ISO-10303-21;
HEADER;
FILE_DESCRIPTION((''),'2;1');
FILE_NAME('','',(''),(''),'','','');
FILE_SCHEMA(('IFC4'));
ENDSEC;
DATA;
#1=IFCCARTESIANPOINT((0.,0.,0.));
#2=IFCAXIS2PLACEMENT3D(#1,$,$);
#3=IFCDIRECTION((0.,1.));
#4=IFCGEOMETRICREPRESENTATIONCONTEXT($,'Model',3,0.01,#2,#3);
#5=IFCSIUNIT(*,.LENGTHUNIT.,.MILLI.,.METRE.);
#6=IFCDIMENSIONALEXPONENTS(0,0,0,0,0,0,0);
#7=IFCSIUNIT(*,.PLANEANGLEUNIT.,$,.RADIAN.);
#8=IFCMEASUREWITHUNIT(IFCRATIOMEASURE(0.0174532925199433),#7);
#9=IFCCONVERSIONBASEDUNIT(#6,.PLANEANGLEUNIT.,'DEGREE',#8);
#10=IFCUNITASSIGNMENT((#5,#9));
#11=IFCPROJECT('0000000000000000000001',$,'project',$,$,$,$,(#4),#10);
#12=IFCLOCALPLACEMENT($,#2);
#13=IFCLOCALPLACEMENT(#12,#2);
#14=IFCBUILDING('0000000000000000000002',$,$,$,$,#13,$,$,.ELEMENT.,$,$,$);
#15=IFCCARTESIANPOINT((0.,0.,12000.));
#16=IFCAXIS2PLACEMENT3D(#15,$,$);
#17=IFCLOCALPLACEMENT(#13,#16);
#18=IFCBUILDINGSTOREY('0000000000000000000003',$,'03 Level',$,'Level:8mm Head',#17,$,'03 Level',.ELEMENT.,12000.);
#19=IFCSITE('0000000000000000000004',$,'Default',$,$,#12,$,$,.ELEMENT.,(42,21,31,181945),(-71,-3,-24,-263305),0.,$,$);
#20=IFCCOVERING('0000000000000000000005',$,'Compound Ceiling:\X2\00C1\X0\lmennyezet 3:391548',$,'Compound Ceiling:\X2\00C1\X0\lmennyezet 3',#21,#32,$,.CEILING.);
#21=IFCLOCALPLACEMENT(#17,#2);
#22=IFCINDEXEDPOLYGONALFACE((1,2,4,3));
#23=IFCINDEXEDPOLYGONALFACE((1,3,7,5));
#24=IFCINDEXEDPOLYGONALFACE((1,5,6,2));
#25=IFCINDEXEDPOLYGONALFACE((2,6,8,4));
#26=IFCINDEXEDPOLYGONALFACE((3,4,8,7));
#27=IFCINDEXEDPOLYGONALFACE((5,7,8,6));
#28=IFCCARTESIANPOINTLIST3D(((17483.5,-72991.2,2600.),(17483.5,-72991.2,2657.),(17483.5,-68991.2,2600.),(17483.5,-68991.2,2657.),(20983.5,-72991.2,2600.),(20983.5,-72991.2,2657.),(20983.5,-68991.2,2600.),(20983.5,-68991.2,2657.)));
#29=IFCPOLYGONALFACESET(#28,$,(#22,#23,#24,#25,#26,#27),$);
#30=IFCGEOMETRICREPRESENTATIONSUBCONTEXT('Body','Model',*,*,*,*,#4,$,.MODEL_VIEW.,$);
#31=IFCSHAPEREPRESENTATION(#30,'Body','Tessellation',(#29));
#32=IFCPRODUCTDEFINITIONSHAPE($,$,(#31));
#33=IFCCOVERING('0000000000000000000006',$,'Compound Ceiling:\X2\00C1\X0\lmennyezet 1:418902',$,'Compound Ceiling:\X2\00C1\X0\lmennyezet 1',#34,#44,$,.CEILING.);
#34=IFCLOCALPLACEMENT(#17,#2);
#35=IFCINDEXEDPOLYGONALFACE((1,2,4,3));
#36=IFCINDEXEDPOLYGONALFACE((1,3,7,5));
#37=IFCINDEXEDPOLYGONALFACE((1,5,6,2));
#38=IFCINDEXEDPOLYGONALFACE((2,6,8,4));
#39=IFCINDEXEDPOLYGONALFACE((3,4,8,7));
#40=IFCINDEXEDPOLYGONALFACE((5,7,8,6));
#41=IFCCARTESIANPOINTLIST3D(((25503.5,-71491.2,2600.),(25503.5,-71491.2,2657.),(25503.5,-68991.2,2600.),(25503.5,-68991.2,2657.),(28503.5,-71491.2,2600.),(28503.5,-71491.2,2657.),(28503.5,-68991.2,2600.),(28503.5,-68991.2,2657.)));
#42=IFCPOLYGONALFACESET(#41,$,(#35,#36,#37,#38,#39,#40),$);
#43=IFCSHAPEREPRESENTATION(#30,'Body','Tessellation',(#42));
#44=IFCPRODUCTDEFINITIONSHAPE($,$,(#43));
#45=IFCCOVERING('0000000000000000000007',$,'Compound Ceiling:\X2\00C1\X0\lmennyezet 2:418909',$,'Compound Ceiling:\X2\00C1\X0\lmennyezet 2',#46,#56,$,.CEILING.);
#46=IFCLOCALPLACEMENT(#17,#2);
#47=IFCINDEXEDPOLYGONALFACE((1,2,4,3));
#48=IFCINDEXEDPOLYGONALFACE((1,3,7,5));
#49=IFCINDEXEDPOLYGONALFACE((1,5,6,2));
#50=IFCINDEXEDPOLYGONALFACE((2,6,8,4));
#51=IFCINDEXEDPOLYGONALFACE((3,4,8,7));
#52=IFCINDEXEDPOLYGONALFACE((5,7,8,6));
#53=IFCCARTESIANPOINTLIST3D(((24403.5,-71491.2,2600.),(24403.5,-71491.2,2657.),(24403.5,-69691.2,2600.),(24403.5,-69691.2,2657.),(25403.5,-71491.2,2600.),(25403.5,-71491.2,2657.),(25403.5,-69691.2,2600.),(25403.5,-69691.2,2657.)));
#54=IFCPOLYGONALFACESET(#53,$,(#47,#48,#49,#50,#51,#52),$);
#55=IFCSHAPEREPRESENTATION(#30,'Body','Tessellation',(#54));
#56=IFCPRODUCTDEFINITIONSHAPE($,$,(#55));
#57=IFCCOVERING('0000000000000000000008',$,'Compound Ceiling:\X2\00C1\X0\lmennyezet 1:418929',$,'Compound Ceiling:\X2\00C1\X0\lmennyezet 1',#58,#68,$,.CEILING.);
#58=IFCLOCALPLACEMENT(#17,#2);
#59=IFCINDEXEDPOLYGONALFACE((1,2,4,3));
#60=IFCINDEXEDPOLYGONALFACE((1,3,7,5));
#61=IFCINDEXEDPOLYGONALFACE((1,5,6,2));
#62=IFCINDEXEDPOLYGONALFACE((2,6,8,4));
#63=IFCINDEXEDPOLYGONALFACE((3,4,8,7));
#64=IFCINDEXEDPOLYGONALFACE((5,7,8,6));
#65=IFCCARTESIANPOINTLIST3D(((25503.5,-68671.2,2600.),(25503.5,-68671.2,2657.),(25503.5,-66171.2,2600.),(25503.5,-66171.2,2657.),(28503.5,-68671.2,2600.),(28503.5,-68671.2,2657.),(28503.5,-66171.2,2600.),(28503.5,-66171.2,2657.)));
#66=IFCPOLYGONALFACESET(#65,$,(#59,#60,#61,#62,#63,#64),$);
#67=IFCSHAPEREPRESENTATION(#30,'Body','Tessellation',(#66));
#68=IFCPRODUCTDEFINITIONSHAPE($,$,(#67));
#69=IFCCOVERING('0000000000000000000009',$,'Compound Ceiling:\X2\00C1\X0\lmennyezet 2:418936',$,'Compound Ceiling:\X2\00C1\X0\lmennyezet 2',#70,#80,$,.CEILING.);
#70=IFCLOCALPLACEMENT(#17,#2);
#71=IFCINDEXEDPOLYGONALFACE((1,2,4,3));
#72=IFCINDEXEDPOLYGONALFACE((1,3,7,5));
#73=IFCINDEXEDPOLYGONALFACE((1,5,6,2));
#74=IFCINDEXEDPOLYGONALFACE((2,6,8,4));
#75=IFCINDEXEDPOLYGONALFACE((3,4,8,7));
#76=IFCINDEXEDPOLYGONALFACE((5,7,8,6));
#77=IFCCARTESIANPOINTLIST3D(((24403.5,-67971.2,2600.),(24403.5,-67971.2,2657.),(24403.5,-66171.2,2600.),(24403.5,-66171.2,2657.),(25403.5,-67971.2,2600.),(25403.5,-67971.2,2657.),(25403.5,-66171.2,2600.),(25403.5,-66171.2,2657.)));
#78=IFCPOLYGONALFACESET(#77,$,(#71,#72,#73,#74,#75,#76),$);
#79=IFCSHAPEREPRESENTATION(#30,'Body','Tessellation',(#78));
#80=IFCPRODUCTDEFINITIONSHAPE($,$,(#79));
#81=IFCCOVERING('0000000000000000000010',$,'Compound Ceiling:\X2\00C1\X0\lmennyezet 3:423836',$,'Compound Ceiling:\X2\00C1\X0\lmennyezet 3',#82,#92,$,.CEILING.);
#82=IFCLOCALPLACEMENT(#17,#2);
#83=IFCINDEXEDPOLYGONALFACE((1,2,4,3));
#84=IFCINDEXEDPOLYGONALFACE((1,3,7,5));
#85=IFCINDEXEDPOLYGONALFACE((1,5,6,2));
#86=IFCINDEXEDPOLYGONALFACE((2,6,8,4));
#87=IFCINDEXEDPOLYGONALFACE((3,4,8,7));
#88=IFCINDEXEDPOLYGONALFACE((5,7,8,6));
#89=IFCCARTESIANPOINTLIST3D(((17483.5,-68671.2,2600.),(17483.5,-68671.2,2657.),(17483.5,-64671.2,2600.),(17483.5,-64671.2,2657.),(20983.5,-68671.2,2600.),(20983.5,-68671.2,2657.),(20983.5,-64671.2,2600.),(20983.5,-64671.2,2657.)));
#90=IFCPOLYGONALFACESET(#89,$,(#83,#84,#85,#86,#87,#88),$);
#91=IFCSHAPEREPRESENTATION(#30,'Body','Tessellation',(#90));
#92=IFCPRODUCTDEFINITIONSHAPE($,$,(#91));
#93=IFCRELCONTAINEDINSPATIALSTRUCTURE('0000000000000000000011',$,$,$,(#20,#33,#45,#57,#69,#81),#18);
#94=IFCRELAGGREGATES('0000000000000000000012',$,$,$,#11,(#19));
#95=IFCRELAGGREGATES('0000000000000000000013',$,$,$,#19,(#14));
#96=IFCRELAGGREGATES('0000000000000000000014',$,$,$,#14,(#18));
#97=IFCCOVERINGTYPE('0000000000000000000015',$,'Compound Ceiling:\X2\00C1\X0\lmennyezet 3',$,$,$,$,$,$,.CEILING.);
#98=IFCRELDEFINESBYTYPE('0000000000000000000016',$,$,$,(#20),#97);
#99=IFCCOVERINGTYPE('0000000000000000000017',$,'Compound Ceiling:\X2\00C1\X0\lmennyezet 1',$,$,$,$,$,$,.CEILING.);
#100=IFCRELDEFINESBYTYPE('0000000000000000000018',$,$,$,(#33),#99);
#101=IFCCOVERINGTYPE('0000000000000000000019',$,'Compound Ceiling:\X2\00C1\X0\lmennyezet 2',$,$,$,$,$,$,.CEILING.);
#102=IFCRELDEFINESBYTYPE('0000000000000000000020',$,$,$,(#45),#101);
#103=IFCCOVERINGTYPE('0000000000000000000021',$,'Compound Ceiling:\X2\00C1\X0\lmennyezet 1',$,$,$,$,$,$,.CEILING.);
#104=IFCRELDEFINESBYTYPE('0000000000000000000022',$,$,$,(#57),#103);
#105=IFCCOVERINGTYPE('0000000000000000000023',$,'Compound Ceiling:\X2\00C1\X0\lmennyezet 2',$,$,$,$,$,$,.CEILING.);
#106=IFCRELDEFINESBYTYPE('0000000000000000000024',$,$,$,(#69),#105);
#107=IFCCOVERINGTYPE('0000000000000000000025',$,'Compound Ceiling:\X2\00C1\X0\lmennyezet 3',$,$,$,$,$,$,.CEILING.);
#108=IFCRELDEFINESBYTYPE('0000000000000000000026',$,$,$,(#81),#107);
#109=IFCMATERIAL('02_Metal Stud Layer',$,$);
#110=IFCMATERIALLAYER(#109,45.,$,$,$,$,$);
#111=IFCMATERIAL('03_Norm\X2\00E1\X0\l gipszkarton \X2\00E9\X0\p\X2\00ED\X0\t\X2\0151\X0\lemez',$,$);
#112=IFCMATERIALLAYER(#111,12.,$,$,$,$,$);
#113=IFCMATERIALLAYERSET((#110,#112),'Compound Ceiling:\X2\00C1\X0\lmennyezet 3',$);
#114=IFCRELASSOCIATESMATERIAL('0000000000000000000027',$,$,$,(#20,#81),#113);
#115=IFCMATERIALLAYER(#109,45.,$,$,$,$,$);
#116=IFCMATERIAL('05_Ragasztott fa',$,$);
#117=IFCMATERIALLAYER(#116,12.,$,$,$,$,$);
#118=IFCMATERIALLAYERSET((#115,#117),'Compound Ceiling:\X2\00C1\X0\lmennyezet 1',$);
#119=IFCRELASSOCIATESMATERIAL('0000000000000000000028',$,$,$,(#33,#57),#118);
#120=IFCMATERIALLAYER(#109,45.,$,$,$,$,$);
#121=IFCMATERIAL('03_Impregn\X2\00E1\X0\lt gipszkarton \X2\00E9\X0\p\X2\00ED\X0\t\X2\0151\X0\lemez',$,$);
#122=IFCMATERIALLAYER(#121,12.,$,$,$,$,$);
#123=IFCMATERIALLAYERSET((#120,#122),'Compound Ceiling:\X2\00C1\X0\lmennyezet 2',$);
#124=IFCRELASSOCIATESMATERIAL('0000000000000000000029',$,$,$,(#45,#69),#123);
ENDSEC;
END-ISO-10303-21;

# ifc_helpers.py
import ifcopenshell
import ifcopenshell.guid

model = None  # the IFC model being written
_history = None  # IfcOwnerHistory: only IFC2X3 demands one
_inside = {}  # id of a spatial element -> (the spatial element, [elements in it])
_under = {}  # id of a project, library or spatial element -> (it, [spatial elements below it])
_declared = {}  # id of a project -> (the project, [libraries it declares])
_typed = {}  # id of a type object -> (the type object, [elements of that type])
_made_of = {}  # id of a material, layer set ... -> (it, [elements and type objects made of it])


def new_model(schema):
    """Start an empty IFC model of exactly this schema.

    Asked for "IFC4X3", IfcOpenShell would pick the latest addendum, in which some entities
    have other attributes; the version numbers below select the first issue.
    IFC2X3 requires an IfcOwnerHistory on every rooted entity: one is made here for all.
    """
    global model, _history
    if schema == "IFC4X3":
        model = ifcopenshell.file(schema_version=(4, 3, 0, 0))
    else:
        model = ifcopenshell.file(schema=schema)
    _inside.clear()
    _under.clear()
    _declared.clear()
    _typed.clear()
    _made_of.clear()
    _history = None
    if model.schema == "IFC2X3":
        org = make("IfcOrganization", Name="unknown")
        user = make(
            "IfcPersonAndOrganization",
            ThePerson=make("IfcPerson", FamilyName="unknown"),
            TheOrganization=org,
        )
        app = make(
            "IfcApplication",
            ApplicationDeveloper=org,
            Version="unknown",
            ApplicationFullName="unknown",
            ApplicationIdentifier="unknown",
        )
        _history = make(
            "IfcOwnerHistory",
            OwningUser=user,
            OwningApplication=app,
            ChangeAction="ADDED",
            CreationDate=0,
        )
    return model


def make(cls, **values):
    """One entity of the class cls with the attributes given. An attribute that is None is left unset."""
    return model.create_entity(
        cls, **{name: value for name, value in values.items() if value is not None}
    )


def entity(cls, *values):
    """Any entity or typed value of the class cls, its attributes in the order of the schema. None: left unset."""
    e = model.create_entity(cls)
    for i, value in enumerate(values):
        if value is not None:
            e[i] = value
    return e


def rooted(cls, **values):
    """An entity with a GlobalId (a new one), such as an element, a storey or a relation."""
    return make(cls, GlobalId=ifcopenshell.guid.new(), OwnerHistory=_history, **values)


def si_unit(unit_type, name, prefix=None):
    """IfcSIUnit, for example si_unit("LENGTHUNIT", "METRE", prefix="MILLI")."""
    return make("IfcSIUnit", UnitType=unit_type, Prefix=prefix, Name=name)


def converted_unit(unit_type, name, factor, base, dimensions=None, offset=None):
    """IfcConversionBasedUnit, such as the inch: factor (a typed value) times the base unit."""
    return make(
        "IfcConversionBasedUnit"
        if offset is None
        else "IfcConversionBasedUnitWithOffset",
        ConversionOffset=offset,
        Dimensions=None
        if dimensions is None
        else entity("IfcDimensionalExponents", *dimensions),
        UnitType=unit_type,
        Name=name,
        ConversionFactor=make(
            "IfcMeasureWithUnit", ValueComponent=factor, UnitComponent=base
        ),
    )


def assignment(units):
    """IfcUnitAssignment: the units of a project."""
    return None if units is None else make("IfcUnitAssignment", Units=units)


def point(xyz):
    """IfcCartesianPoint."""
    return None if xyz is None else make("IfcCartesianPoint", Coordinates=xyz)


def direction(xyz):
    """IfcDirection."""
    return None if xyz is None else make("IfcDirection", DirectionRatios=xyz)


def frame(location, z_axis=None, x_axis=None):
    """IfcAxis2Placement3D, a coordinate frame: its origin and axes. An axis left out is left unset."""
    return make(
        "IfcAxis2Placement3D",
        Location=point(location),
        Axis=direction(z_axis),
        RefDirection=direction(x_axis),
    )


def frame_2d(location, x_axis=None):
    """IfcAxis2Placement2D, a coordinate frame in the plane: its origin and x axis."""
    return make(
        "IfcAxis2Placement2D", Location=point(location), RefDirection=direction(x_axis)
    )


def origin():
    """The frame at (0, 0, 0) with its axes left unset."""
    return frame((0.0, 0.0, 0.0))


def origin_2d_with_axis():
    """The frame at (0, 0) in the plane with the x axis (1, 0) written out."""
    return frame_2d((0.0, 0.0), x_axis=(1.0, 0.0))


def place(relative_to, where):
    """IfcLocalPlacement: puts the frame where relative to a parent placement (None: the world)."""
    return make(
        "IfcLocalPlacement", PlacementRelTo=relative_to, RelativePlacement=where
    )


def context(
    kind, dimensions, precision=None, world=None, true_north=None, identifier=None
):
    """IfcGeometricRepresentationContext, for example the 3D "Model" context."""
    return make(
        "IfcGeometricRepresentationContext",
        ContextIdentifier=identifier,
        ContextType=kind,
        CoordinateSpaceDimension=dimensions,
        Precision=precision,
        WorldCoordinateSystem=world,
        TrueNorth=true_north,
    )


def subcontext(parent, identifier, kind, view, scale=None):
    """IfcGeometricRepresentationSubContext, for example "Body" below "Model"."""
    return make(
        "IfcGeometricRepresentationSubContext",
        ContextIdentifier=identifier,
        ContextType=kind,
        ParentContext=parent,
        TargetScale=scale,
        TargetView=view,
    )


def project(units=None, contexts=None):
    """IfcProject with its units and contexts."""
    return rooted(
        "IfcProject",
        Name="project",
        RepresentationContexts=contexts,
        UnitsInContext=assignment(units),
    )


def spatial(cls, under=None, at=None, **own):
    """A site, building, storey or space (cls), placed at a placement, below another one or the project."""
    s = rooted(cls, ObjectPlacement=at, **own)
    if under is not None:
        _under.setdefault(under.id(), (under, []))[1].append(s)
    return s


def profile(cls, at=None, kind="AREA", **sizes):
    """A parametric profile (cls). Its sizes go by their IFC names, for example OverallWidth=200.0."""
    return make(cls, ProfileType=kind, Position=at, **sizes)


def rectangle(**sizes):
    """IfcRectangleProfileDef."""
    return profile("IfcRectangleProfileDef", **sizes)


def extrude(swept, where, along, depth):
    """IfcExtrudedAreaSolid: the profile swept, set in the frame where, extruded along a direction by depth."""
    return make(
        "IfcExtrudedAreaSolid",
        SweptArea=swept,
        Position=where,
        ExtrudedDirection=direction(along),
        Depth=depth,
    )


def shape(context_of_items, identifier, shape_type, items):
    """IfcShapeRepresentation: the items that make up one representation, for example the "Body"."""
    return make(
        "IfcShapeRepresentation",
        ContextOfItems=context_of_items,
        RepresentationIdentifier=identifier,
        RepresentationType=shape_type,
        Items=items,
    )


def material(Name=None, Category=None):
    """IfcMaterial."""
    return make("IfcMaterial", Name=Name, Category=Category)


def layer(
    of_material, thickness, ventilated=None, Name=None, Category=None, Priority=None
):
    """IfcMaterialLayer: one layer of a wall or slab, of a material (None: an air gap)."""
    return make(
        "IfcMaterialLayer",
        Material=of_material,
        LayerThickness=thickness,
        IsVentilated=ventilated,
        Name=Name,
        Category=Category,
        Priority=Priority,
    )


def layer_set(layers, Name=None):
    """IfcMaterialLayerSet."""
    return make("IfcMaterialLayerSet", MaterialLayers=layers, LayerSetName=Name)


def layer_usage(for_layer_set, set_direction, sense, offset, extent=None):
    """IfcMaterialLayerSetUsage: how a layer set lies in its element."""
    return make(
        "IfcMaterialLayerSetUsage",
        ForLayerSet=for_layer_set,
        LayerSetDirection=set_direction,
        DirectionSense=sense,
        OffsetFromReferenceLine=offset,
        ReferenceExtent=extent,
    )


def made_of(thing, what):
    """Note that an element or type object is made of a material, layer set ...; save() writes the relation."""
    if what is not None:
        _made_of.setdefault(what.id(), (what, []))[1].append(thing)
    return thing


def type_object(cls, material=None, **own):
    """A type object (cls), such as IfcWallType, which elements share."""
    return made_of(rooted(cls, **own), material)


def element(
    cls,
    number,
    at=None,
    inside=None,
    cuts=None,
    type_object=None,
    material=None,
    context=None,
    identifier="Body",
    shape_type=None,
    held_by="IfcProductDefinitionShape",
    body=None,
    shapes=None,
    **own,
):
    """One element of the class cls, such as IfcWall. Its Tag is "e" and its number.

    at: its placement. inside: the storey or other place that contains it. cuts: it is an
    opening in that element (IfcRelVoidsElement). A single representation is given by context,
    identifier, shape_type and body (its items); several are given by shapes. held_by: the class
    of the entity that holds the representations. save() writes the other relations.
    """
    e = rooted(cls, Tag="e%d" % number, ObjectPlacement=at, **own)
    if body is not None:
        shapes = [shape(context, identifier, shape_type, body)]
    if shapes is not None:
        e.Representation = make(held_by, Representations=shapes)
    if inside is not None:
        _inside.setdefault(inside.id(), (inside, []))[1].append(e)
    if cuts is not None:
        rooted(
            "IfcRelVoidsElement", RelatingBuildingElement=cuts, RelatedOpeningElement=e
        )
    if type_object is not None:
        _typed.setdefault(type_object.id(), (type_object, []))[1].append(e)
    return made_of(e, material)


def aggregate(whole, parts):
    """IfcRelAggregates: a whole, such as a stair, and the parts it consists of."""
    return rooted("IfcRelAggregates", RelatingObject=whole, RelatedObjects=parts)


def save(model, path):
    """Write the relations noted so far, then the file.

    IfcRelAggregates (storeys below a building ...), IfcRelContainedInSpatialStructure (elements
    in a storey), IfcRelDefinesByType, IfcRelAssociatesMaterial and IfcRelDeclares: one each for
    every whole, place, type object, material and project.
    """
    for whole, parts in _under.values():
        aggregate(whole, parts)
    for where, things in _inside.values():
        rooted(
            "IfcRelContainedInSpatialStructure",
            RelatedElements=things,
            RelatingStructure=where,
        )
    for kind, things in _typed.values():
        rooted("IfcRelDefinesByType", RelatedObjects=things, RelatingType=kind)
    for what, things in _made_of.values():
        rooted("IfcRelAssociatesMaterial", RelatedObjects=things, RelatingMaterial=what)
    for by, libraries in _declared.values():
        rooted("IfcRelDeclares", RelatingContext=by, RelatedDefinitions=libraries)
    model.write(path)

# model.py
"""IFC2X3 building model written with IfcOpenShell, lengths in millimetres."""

from ifc_helpers import new_model, entity, si_unit, converted_unit, direction, frame, frame_2d, origin, origin_2d_with_axis, place, context, subcontext, project, spatial, rectangle, extrude, material, layer, layer_set, layer_usage, type_object, element, save


model = new_model("IFC2X3")

# Units and contexts
model_context = context("Model", 3, precision=0.01, world=origin(), true_north=direction((0.0, 1.0)))
body_context = subcontext(model_context, "Body", "Model", "MODEL_VIEW")
ifc_project = project(units=[si_unit("LENGTHUNIT", "METRE", prefix="MILLI"), converted_unit("PLANEANGLEUNIT", "DEGREE", entity("IfcRatioMeasure", 0.0174532925199433), si_unit("PLANEANGLEUNIT", "RADIAN"), dimensions=[0, 0, 0, 0, 0, 0, 0])], contexts=[model_context])

# Site, building, storey
site_placement = place(None, origin())
site = spatial("IfcSite", under=ifc_project, at=site_placement, Name="Default", CompositionType="ELEMENT", RefLatitude=(42, 21, 31, 181945), RefLongitude=(-71, -3, -24, -263305), RefElevation=0.0)
building_placement = place(site_placement, origin())
building = spatial("IfcBuilding", under=site, at=building_placement, CompositionType="ELEMENT")
storey_placement = place(building_placement, frame((0.0, 0.0, 12000.0)))
storey = spatial("IfcBuildingStorey", under=building, at=storey_placement, Name="03 Level", ObjectType="Level:8mm Head", LongName="03 Level", CompositionType="ELEMENT", Elevation=12000.0)

# Coverings
ifc_material_1 = material(Name="02_Metal Stud Layer")
ifc_layer_1 = layer(ifc_material_1, 45.0)
ifc_material_2 = material(Name="03_Normál gipszkarton építőlemez")
ifc_layer_2 = layer(ifc_material_2, 12.0)
ifc_layer_set_1 = layer_set([ifc_layer_1, ifc_layer_2], Name="Compound Ceiling:Álmennyezet 3")
ifc_layer_usage_1 = layer_usage(ifc_layer_set_1, "AXIS3", "POSITIVE", 0.0)
covering_type_1 = type_object("IfcCoveringType", Name="Compound Ceiling:Álmennyezet 3", PredefinedType="CEILING")
covering_1_placement = place(storey_placement, frame((17483.5, -72991.2, 2600.0)))
element("IfcCovering", 1, at=covering_1_placement, inside=storey, type_object=covering_type_1, material=ifc_layer_usage_1, Name="Compound Ceiling:Álmennyezet 3:391548", ObjectType="Compound Ceiling:Álmennyezet 3", PredefinedType="CEILING", context=body_context, shape_type="SweptSolid", body=[
    extrude(rectangle(XDim=4000.0, YDim=3500.0, at=frame_2d((0.0, 0.0), x_axis=(1.0, 0.0))), frame((1750.0, 2000.0, 0.0), z_axis=(0.0, 0.0, 1.0), x_axis=(0.0, 1.0, 0.0)), (0.0, 0.0, 1.0), 57.0),
])
ifc_layer_3 = layer(ifc_material_1, 45.0)
ifc_material_3 = material(Name="05_Ragasztott fa")
ifc_layer_4 = layer(ifc_material_3, 12.0)
ifc_layer_set_2 = layer_set([ifc_layer_3, ifc_layer_4], Name="Compound Ceiling:Álmennyezet 1")
ifc_layer_usage_2 = layer_usage(ifc_layer_set_2, "AXIS3", "POSITIVE", 0.0)
covering_type_2 = type_object("IfcCoveringType", Name="Compound Ceiling:Álmennyezet 1", PredefinedType="CEILING")
covering_2_placement = place(storey_placement, frame((25503.5, -71491.2, 2600.0)))
element("IfcCovering", 2, at=covering_2_placement, inside=storey, type_object=covering_type_2, material=ifc_layer_usage_2, Name="Compound Ceiling:Álmennyezet 1:418902", ObjectType="Compound Ceiling:Álmennyezet 1", PredefinedType="CEILING", context=body_context, shape_type="SweptSolid", body=[
    extrude(rectangle(XDim=3000.0, YDim=2500.0, at=frame_2d((0.0, 0.0), x_axis=(1.0, 0.0))), frame((1500.0, 1250.0, 0.0), z_axis=(0.0, 0.0, 1.0), x_axis=(-1.0, 0.0, 0.0)), (0.0, 0.0, 1.0), 57.0),
])
ifc_layer_5 = layer(ifc_material_1, 45.0)
ifc_material_4 = material(Name="03_Impregnált gipszkarton építőlemez")
ifc_layer_6 = layer(ifc_material_4, 12.0)
ifc_layer_set_3 = layer_set([ifc_layer_5, ifc_layer_6], Name="Compound Ceiling:Álmennyezet 2")
ifc_layer_usage_3 = layer_usage(ifc_layer_set_3, "AXIS3", "POSITIVE", 0.0)
covering_type_3 = type_object("IfcCoveringType", Name="Compound Ceiling:Álmennyezet 2", PredefinedType="CEILING")
covering_3_placement = place(storey_placement, frame((24403.5, -71491.2, 2600.0)))
element("IfcCovering", 3, at=covering_3_placement, inside=storey, type_object=covering_type_3, material=ifc_layer_usage_3, Name="Compound Ceiling:Álmennyezet 2:418909", ObjectType="Compound Ceiling:Álmennyezet 2", PredefinedType="CEILING", context=body_context, shape_type="SweptSolid", body=[
    extrude(rectangle(XDim=1000.0, YDim=1800.0, at=frame_2d((0.0, 0.0), x_axis=(1.0, 0.0))), frame((500.0, 900.0, 0.0), z_axis=(0.0, 0.0, 1.0), x_axis=(-1.0, 0.0, 0.0)), (0.0, 0.0, 1.0), 57.0),
])
ifc_layer_usage_4 = layer_usage(ifc_layer_set_2, "AXIS3", "POSITIVE", 0.0)
covering_type_4 = type_object("IfcCoveringType", Name="Compound Ceiling:Álmennyezet 1", PredefinedType="CEILING")
covering_4_placement = place(storey_placement, frame((25503.5, -68671.2, 2600.0)))
element("IfcCovering", 4, at=covering_4_placement, inside=storey, type_object=covering_type_4, material=ifc_layer_usage_4, Name="Compound Ceiling:Álmennyezet 1:418929", ObjectType="Compound Ceiling:Álmennyezet 1", PredefinedType="CEILING", context=body_context, shape_type="SweptSolid", body=[
    extrude(rectangle(XDim=2500.0, YDim=3000.0, at=frame_2d((0.0, 0.0), x_axis=(1.0, 0.0))), frame((1500.0, 1250.0, 0.0), z_axis=(0.0, 0.0, 1.0), x_axis=(0.0, 1.0, 0.0)), (0.0, 0.0, 1.0), 57.0),
])
ifc_layer_usage_5 = layer_usage(ifc_layer_set_3, "AXIS3", "POSITIVE", 0.0)
covering_type_5 = type_object("IfcCoveringType", Name="Compound Ceiling:Álmennyezet 2", PredefinedType="CEILING")
covering_5_placement = place(storey_placement, frame((24403.5, -67971.2, 2600.0)))
element("IfcCovering", 5, at=covering_5_placement, inside=storey, type_object=covering_type_5, material=ifc_layer_usage_5, Name="Compound Ceiling:Álmennyezet 2:418936", ObjectType="Compound Ceiling:Álmennyezet 2", PredefinedType="CEILING", context=body_context, shape_type="SweptSolid", body=[
    extrude(rectangle(XDim=1800.0, YDim=1000.0, at=origin_2d_with_axis()), frame((500.0, 900.0, 0.0), z_axis=(0.0, 0.0, 1.0), x_axis=(0.0, 1.0, 0.0)), (0.0, 0.0, 1.0), 57.0),
])
ifc_layer_usage_6 = layer_usage(ifc_layer_set_1, "AXIS3", "POSITIVE", 0.0)
covering_type_6 = type_object("IfcCoveringType", Name="Compound Ceiling:Álmennyezet 3", PredefinedType="CEILING")
covering_6_placement = place(storey_placement, frame((17483.5, -68671.2, 2600.0)))
element("IfcCovering", 6, at=covering_6_placement, inside=storey, type_object=covering_type_6, material=ifc_layer_usage_6, Name="Compound Ceiling:Álmennyezet 3:423836", ObjectType="Compound Ceiling:Álmennyezet 3", PredefinedType="CEILING", context=body_context, shape_type="SweptSolid", body=[
    extrude(rectangle(XDim=3500.0, YDim=4000.0, at=origin_2d_with_axis()), frame((1750.0, 2000.0, 0.0), z_axis=(0.0, 0.0, 1.0), x_axis=(-1.0, 0.0, 0.0)), (0.0, 0.0, 1.0), 57.0),
])

save(model, "model.ifc")
